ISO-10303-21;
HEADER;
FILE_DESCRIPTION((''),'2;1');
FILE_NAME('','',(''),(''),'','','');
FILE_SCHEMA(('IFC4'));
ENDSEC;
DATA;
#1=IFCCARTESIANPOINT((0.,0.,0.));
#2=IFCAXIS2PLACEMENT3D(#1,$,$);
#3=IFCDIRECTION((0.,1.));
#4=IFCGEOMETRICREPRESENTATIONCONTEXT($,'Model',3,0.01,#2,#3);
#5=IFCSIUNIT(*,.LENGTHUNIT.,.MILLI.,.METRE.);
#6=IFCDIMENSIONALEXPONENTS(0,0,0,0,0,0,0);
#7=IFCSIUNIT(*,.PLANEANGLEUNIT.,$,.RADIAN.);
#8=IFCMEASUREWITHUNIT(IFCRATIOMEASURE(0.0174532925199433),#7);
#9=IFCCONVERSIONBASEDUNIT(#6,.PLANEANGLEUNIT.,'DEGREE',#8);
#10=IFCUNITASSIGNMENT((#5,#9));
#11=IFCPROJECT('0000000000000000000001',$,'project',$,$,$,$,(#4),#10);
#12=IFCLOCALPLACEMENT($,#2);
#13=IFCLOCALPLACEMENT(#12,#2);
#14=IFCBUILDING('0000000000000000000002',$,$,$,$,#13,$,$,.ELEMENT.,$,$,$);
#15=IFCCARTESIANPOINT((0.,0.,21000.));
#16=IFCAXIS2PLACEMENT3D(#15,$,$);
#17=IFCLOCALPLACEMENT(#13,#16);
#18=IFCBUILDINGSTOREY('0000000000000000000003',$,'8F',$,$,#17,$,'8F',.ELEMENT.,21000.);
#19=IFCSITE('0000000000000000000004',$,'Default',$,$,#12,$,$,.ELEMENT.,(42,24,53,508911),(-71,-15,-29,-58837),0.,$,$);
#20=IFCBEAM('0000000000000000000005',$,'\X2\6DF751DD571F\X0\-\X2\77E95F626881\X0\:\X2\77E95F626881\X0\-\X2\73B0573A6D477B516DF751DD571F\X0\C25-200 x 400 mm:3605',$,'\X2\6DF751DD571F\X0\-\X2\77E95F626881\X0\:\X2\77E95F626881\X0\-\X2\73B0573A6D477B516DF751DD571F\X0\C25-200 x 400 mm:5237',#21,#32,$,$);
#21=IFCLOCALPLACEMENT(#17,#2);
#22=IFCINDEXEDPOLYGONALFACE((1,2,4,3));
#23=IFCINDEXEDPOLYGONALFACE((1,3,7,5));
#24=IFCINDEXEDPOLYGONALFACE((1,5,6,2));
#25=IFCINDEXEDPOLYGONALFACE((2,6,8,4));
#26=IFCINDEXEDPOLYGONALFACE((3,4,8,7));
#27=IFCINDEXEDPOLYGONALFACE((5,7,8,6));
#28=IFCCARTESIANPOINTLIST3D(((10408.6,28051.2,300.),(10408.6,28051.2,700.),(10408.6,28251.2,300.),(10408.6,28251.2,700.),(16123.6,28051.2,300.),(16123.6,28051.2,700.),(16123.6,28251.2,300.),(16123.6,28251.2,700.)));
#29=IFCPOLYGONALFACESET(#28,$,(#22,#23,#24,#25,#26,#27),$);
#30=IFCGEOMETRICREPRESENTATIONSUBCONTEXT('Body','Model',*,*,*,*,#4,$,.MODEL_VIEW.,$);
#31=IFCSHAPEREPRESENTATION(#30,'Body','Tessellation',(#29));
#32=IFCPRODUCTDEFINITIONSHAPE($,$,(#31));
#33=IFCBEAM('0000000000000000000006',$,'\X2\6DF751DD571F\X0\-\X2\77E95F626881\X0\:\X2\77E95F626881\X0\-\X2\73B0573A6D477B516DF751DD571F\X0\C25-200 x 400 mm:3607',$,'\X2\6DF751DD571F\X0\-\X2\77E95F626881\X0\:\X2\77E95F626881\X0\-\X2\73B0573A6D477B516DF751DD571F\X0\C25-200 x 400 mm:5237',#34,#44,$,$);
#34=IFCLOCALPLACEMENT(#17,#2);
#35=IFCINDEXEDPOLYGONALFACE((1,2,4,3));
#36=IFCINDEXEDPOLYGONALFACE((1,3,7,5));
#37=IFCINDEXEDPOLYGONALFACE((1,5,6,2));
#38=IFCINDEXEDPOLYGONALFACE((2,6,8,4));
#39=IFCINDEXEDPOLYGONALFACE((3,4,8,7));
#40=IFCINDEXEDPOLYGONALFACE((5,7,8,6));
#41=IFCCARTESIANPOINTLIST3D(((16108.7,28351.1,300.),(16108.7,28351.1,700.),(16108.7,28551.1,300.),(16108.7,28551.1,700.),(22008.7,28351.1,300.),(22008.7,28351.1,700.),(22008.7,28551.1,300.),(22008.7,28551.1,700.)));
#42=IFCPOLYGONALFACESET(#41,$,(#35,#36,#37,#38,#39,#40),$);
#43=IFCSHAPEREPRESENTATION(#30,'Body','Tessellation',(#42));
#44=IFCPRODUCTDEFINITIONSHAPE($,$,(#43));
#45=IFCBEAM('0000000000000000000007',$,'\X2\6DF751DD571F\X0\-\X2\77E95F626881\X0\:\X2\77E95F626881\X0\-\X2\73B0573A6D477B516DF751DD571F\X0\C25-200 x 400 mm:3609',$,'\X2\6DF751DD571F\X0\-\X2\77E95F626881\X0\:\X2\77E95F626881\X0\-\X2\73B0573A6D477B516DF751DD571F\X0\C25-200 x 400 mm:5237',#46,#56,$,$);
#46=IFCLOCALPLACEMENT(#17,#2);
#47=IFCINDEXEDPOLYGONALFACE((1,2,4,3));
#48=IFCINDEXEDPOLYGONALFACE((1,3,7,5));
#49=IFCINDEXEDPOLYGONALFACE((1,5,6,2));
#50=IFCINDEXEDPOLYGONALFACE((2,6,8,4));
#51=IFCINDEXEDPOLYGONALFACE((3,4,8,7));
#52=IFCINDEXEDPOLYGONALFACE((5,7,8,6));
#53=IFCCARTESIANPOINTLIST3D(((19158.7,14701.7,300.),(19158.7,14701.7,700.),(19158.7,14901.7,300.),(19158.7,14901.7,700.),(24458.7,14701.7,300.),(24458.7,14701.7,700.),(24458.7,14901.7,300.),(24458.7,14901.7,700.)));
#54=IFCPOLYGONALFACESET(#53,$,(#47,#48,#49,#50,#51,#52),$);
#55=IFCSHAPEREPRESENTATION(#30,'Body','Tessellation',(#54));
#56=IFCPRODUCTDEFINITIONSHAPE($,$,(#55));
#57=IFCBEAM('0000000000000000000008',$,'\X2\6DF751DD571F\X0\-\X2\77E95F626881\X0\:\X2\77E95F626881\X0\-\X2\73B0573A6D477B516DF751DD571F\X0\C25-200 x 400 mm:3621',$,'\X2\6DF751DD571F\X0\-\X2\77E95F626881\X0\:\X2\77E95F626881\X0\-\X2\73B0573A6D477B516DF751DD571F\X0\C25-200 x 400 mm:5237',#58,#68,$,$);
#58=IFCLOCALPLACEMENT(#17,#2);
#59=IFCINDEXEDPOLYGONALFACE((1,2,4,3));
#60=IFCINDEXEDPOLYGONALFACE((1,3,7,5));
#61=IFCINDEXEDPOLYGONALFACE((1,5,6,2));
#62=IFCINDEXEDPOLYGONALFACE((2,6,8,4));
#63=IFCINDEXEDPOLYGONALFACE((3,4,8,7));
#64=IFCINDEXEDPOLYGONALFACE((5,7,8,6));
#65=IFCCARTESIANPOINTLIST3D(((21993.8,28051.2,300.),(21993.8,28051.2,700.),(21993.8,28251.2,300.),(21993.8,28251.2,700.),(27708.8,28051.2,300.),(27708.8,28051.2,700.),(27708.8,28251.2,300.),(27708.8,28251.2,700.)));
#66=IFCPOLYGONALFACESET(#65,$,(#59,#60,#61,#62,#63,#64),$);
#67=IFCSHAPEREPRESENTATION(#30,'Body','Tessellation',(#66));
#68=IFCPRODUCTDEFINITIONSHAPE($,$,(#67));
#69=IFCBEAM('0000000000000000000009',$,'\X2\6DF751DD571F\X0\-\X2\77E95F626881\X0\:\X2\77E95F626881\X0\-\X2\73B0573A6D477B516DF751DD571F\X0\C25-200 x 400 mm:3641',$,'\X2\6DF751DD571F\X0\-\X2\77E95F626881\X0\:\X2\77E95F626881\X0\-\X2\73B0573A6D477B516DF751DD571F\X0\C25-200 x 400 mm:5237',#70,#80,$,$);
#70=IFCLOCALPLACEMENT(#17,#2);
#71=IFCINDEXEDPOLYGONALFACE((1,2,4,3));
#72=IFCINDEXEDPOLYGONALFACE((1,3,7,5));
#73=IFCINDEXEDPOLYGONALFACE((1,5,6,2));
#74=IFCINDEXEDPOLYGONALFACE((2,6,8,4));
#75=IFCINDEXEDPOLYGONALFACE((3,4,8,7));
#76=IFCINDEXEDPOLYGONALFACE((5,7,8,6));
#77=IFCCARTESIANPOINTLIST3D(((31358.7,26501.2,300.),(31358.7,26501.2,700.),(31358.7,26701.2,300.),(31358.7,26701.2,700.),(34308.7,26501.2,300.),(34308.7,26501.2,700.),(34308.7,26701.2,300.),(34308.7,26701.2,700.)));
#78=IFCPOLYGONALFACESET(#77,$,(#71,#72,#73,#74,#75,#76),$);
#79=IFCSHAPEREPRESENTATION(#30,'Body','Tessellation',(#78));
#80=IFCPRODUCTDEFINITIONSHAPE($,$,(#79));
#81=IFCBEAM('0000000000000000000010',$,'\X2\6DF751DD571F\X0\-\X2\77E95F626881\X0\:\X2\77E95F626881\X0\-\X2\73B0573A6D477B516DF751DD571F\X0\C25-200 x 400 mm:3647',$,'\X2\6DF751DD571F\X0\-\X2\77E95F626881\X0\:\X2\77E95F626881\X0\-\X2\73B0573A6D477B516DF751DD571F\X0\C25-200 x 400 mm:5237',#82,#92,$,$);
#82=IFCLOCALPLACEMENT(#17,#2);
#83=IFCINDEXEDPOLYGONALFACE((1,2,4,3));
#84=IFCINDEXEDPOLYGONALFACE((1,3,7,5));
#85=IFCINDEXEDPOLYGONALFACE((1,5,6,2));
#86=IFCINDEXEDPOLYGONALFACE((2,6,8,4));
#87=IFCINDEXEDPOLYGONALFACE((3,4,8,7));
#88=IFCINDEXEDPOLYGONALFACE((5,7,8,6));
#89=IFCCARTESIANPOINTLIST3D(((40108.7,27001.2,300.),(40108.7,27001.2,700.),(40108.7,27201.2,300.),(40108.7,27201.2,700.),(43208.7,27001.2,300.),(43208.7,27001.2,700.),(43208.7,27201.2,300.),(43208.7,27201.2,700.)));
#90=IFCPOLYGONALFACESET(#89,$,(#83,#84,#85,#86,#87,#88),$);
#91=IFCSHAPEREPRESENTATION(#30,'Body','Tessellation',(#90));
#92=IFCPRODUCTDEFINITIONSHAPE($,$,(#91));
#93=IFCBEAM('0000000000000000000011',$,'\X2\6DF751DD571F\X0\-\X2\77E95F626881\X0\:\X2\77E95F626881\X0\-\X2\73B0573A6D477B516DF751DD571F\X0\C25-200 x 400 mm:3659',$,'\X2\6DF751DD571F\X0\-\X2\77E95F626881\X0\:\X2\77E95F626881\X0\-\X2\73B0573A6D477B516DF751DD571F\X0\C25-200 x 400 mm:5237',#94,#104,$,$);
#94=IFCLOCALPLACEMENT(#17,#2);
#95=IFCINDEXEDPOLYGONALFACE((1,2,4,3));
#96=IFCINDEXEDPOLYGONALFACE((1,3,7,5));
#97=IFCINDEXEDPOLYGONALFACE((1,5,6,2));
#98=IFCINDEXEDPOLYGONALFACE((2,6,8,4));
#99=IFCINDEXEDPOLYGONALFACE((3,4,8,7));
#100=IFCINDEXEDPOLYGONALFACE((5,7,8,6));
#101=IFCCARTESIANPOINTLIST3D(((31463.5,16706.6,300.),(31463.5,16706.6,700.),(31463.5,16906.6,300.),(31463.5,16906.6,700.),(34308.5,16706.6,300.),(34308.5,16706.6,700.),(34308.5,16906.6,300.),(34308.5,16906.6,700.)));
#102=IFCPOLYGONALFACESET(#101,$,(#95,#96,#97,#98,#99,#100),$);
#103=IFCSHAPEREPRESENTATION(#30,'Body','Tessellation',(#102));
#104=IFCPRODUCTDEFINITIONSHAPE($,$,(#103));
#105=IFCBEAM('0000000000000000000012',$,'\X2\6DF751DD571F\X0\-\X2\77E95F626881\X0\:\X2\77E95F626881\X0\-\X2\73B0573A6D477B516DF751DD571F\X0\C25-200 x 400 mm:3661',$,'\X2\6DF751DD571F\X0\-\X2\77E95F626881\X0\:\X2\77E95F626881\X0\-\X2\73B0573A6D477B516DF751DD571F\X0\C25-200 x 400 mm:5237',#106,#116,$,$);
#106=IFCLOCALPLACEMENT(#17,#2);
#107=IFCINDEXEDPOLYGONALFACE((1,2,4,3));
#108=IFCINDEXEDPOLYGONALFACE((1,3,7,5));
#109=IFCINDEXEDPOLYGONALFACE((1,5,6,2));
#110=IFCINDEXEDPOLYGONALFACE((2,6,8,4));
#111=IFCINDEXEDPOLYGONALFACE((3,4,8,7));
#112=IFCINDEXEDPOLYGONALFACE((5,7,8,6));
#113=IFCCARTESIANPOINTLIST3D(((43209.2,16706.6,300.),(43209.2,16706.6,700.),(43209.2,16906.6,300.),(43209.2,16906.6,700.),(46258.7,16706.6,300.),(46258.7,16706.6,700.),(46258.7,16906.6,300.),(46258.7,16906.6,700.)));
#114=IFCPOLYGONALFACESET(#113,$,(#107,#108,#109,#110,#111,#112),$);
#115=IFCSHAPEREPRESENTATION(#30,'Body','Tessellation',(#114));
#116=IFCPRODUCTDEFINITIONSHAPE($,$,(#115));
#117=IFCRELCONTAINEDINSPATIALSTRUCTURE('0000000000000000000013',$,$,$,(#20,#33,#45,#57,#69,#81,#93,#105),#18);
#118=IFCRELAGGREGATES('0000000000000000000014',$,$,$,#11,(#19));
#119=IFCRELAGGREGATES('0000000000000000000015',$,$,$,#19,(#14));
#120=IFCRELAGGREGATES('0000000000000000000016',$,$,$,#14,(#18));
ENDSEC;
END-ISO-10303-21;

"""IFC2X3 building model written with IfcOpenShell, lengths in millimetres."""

from ifc_helpers import new_model, entity, si_unit, converted_unit, direction, frame, frame_2d, origin, place, context, subcontext, project, spatial, rectangle, extrude, element, save


model = new_model("IFC2X3")

# Units and contexts
model_context = context("Model", 3, precision=0.01, world=origin(), true_north=direction((0.0, 1.0)))
body_context = subcontext(model_context, "Body", "Model", "MODEL_VIEW")
ifc_project = project(units=[si_unit("LENGTHUNIT", "METRE", prefix="MILLI"), converted_unit("PLANEANGLEUNIT", "DEGREE", entity("IfcRatioMeasure", 0.0174532925199433), si_unit("PLANEANGLEUNIT", "RADIAN"), dimensions=[0, 0, 0, 0, 0, 0, 0])], contexts=[model_context])

# Site, building, storey
site_placement = place(None, origin())
site = spatial("IfcSite", under=ifc_project, at=site_placement, Name="Default", CompositionType="ELEMENT", RefLatitude=(42, 24, 53, 508911), RefLongitude=(-71, -15, -29, -58837), RefElevation=0.0)
building_placement = place(site_placement, origin())
building = spatial("IfcBuilding", under=site, at=building_placement, CompositionType="ELEMENT")
storey_placement = place(building_placement, frame((0.0, 0.0, 21000.0)))
storey = spatial("IfcBuildingStorey", under=building, at=storey_placement, Name="8F", LongName="8F", CompositionType="ELEMENT", Elevation=21000.0)

# Beams
beam_1_placement = place(storey_placement, frame((10408.6, 28151.2, 700.0)))
element("IfcBeam", 1, at=beam_1_placement, inside=storey, Name="混凝土-矩形梁:矩形梁-现场浇筑混凝土C25-200 x 400 mm:3605", ObjectType="混凝土-矩形梁:矩形梁-现场浇筑混凝土C25-200 x 400 mm:5237", context=body_context, shape_type="SweptSolid", body=[
    extrude(rectangle(XDim=400.0, YDim=200.0, at=frame_2d((0.0, 0.0), x_axis=(1.0, 0.0))), frame((0.0, 0.0, -200.0), z_axis=(1.0, 0.0, 0.0), x_axis=(0.0, 0.0, -1.0)), (0.0, 0.0, 1.0), 5715.0),
])
beam_2_placement = place(storey_placement, frame((16108.7, 28451.1, 700.0)))
element("IfcBeam", 2, at=beam_2_placement, inside=storey, Name="混凝土-矩形梁:矩形梁-现场浇筑混凝土C25-200 x 400 mm:3607", ObjectType="混凝土-矩形梁:矩形梁-现场浇筑混凝土C25-200 x 400 mm:5237", context=body_context, shape_type="SweptSolid", body=[
    extrude(rectangle(XDim=400.0, YDim=200.0, at=frame_2d((0.0, 0.0), x_axis=(1.0, 0.0))), frame((0.0, 0.0, -200.0), z_axis=(1.0, 0.0, 0.0), x_axis=(0.0, 0.0, -1.0)), (0.0, 0.0, 1.0), 5900.0),
])
beam_3_placement = place(storey_placement, frame((24458.7, 14801.7, 700.0), z_axis=(0.0, 0.0, 1.0), x_axis=(-1.0, 0.0, 0.0)))
element("IfcBeam", 3, at=beam_3_placement, inside=storey, Name="混凝土-矩形梁:矩形梁-现场浇筑混凝土C25-200 x 400 mm:3609", ObjectType="混凝土-矩形梁:矩形梁-现场浇筑混凝土C25-200 x 400 mm:5237", context=body_context, shape_type="SweptSolid", body=[
    extrude(rectangle(XDim=400.0, YDim=200.0, at=frame_2d((0.0, 0.0), x_axis=(1.0, 0.0))), frame((0.0, 0.0, -200.0), z_axis=(1.0, 0.0, 0.0), x_axis=(0.0, 0.0, -1.0)), (0.0, 0.0, 1.0), 5300.0),
])
beam_4_placement = place(storey_placement, frame((27708.8, 28151.2, 700.0), z_axis=(0.0, 0.0, 1.0), x_axis=(-1.0, 0.0, 0.0)))
element("IfcBeam", 4, at=beam_4_placement, inside=storey, Name="混凝土-矩形梁:矩形梁-现场浇筑混凝土C25-200 x 400 mm:3621", ObjectType="混凝土-矩形梁:矩形梁-现场浇筑混凝土C25-200 x 400 mm:5237", context=body_context, shape_type="SweptSolid", body=[
    extrude(rectangle(XDim=400.0, YDim=200.0, at=frame_2d((0.0, 0.0), x_axis=(1.0, 0.0))), frame((0.0, 0.0, -200.0), z_axis=(1.0, 0.0, 0.0), x_axis=(0.0, 0.0, -1.0)), (0.0, 0.0, 1.0), 5715.0),
])
beam_5_placement = place(storey_placement, frame((34308.7, 26601.2, 700.0), z_axis=(0.0, 0.0, 1.0), x_axis=(-1.0, 0.0, 0.0)))
element("IfcBeam", 5, at=beam_5_placement, inside=storey, Name="混凝土-矩形梁:矩形梁-现场浇筑混凝土C25-200 x 400 mm:3641", ObjectType="混凝土-矩形梁:矩形梁-现场浇筑混凝土C25-200 x 400 mm:5237", context=body_context, shape_type="SweptSolid", body=[
    extrude(rectangle(XDim=400.0, YDim=200.0, at=frame_2d((0.0, 0.0), x_axis=(1.0, 0.0))), frame((0.0, 0.0, -200.0), z_axis=(1.0, 0.0, 0.0), x_axis=(0.0, 0.0, -1.0)), (0.0, 0.0, 1.0), 2950.0),
])
beam_6_placement = place(storey_placement, frame((43208.7, 27101.2, 700.0), z_axis=(0.0, 0.0, 1.0), x_axis=(-1.0, 0.0, 0.0)))
element("IfcBeam", 6, at=beam_6_placement, inside=storey, Name="混凝土-矩形梁:矩形梁-现场浇筑混凝土C25-200 x 400 mm:3647", ObjectType="混凝土-矩形梁:矩形梁-现场浇筑混凝土C25-200 x 400 mm:5237", context=body_context, shape_type="SweptSolid", body=[
    extrude(rectangle(XDim=400.0, YDim=200.0, at=frame_2d((0.0, 0.0), x_axis=(1.0, 0.0))), frame((0.0, 0.0, -200.0), z_axis=(1.0, 0.0, 0.0), x_axis=(0.0, 0.0, -1.0)), (0.0, 0.0, 1.0), 3100.0),
])
beam_7_placement = place(storey_placement, frame((31463.3, 16806.6, 700.0)))
element("IfcBeam", 7, at=beam_7_placement, inside=storey, Name="混凝土-矩形梁:矩形梁-现场浇筑混凝土C25-200 x 400 mm:3659", ObjectType="混凝土-矩形梁:矩形梁-现场浇筑混凝土C25-200 x 400 mm:5237", context=body_context, shape_type="SweptSolid", body=[
    extrude(rectangle(XDim=400.0, YDim=200.0, at=frame_2d((0.0, 0.0), x_axis=(1.0, 0.0))), frame((0.2, 0.0, -200.0), z_axis=(1.0, 0.0, 0.0), x_axis=(0.0, 0.0, -1.0)), (0.0, 0.0, 1.0), 2845.0),
])
beam_8_placement = place(storey_placement, frame((46158.7, 16806.6, 700.0), z_axis=(0.0, 0.0, 1.0), x_axis=(-1.0, 0.0, 0.0)))
element("IfcBeam", 8, at=beam_8_placement, inside=storey, Name="混凝土-矩形梁:矩形梁-现场浇筑混凝土C25-200 x 400 mm:3661", ObjectType="混凝土-矩形梁:矩形梁-现场浇筑混凝土C25-200 x 400 mm:5237", context=body_context, shape_type="SweptSolid", body=[
    extrude(rectangle(XDim=400.0, YDim=200.0, at=frame_2d((0.0, 0.0), x_axis=(1.0, 0.0))), frame((-100.0, 0.0, -200.0), z_axis=(1.0, 0.0, 0.0), x_axis=(0.0, 0.0, -1.0)), (0.0, 0.0, 1.0), 3049.5),
])

save(model, "model.ifc")
